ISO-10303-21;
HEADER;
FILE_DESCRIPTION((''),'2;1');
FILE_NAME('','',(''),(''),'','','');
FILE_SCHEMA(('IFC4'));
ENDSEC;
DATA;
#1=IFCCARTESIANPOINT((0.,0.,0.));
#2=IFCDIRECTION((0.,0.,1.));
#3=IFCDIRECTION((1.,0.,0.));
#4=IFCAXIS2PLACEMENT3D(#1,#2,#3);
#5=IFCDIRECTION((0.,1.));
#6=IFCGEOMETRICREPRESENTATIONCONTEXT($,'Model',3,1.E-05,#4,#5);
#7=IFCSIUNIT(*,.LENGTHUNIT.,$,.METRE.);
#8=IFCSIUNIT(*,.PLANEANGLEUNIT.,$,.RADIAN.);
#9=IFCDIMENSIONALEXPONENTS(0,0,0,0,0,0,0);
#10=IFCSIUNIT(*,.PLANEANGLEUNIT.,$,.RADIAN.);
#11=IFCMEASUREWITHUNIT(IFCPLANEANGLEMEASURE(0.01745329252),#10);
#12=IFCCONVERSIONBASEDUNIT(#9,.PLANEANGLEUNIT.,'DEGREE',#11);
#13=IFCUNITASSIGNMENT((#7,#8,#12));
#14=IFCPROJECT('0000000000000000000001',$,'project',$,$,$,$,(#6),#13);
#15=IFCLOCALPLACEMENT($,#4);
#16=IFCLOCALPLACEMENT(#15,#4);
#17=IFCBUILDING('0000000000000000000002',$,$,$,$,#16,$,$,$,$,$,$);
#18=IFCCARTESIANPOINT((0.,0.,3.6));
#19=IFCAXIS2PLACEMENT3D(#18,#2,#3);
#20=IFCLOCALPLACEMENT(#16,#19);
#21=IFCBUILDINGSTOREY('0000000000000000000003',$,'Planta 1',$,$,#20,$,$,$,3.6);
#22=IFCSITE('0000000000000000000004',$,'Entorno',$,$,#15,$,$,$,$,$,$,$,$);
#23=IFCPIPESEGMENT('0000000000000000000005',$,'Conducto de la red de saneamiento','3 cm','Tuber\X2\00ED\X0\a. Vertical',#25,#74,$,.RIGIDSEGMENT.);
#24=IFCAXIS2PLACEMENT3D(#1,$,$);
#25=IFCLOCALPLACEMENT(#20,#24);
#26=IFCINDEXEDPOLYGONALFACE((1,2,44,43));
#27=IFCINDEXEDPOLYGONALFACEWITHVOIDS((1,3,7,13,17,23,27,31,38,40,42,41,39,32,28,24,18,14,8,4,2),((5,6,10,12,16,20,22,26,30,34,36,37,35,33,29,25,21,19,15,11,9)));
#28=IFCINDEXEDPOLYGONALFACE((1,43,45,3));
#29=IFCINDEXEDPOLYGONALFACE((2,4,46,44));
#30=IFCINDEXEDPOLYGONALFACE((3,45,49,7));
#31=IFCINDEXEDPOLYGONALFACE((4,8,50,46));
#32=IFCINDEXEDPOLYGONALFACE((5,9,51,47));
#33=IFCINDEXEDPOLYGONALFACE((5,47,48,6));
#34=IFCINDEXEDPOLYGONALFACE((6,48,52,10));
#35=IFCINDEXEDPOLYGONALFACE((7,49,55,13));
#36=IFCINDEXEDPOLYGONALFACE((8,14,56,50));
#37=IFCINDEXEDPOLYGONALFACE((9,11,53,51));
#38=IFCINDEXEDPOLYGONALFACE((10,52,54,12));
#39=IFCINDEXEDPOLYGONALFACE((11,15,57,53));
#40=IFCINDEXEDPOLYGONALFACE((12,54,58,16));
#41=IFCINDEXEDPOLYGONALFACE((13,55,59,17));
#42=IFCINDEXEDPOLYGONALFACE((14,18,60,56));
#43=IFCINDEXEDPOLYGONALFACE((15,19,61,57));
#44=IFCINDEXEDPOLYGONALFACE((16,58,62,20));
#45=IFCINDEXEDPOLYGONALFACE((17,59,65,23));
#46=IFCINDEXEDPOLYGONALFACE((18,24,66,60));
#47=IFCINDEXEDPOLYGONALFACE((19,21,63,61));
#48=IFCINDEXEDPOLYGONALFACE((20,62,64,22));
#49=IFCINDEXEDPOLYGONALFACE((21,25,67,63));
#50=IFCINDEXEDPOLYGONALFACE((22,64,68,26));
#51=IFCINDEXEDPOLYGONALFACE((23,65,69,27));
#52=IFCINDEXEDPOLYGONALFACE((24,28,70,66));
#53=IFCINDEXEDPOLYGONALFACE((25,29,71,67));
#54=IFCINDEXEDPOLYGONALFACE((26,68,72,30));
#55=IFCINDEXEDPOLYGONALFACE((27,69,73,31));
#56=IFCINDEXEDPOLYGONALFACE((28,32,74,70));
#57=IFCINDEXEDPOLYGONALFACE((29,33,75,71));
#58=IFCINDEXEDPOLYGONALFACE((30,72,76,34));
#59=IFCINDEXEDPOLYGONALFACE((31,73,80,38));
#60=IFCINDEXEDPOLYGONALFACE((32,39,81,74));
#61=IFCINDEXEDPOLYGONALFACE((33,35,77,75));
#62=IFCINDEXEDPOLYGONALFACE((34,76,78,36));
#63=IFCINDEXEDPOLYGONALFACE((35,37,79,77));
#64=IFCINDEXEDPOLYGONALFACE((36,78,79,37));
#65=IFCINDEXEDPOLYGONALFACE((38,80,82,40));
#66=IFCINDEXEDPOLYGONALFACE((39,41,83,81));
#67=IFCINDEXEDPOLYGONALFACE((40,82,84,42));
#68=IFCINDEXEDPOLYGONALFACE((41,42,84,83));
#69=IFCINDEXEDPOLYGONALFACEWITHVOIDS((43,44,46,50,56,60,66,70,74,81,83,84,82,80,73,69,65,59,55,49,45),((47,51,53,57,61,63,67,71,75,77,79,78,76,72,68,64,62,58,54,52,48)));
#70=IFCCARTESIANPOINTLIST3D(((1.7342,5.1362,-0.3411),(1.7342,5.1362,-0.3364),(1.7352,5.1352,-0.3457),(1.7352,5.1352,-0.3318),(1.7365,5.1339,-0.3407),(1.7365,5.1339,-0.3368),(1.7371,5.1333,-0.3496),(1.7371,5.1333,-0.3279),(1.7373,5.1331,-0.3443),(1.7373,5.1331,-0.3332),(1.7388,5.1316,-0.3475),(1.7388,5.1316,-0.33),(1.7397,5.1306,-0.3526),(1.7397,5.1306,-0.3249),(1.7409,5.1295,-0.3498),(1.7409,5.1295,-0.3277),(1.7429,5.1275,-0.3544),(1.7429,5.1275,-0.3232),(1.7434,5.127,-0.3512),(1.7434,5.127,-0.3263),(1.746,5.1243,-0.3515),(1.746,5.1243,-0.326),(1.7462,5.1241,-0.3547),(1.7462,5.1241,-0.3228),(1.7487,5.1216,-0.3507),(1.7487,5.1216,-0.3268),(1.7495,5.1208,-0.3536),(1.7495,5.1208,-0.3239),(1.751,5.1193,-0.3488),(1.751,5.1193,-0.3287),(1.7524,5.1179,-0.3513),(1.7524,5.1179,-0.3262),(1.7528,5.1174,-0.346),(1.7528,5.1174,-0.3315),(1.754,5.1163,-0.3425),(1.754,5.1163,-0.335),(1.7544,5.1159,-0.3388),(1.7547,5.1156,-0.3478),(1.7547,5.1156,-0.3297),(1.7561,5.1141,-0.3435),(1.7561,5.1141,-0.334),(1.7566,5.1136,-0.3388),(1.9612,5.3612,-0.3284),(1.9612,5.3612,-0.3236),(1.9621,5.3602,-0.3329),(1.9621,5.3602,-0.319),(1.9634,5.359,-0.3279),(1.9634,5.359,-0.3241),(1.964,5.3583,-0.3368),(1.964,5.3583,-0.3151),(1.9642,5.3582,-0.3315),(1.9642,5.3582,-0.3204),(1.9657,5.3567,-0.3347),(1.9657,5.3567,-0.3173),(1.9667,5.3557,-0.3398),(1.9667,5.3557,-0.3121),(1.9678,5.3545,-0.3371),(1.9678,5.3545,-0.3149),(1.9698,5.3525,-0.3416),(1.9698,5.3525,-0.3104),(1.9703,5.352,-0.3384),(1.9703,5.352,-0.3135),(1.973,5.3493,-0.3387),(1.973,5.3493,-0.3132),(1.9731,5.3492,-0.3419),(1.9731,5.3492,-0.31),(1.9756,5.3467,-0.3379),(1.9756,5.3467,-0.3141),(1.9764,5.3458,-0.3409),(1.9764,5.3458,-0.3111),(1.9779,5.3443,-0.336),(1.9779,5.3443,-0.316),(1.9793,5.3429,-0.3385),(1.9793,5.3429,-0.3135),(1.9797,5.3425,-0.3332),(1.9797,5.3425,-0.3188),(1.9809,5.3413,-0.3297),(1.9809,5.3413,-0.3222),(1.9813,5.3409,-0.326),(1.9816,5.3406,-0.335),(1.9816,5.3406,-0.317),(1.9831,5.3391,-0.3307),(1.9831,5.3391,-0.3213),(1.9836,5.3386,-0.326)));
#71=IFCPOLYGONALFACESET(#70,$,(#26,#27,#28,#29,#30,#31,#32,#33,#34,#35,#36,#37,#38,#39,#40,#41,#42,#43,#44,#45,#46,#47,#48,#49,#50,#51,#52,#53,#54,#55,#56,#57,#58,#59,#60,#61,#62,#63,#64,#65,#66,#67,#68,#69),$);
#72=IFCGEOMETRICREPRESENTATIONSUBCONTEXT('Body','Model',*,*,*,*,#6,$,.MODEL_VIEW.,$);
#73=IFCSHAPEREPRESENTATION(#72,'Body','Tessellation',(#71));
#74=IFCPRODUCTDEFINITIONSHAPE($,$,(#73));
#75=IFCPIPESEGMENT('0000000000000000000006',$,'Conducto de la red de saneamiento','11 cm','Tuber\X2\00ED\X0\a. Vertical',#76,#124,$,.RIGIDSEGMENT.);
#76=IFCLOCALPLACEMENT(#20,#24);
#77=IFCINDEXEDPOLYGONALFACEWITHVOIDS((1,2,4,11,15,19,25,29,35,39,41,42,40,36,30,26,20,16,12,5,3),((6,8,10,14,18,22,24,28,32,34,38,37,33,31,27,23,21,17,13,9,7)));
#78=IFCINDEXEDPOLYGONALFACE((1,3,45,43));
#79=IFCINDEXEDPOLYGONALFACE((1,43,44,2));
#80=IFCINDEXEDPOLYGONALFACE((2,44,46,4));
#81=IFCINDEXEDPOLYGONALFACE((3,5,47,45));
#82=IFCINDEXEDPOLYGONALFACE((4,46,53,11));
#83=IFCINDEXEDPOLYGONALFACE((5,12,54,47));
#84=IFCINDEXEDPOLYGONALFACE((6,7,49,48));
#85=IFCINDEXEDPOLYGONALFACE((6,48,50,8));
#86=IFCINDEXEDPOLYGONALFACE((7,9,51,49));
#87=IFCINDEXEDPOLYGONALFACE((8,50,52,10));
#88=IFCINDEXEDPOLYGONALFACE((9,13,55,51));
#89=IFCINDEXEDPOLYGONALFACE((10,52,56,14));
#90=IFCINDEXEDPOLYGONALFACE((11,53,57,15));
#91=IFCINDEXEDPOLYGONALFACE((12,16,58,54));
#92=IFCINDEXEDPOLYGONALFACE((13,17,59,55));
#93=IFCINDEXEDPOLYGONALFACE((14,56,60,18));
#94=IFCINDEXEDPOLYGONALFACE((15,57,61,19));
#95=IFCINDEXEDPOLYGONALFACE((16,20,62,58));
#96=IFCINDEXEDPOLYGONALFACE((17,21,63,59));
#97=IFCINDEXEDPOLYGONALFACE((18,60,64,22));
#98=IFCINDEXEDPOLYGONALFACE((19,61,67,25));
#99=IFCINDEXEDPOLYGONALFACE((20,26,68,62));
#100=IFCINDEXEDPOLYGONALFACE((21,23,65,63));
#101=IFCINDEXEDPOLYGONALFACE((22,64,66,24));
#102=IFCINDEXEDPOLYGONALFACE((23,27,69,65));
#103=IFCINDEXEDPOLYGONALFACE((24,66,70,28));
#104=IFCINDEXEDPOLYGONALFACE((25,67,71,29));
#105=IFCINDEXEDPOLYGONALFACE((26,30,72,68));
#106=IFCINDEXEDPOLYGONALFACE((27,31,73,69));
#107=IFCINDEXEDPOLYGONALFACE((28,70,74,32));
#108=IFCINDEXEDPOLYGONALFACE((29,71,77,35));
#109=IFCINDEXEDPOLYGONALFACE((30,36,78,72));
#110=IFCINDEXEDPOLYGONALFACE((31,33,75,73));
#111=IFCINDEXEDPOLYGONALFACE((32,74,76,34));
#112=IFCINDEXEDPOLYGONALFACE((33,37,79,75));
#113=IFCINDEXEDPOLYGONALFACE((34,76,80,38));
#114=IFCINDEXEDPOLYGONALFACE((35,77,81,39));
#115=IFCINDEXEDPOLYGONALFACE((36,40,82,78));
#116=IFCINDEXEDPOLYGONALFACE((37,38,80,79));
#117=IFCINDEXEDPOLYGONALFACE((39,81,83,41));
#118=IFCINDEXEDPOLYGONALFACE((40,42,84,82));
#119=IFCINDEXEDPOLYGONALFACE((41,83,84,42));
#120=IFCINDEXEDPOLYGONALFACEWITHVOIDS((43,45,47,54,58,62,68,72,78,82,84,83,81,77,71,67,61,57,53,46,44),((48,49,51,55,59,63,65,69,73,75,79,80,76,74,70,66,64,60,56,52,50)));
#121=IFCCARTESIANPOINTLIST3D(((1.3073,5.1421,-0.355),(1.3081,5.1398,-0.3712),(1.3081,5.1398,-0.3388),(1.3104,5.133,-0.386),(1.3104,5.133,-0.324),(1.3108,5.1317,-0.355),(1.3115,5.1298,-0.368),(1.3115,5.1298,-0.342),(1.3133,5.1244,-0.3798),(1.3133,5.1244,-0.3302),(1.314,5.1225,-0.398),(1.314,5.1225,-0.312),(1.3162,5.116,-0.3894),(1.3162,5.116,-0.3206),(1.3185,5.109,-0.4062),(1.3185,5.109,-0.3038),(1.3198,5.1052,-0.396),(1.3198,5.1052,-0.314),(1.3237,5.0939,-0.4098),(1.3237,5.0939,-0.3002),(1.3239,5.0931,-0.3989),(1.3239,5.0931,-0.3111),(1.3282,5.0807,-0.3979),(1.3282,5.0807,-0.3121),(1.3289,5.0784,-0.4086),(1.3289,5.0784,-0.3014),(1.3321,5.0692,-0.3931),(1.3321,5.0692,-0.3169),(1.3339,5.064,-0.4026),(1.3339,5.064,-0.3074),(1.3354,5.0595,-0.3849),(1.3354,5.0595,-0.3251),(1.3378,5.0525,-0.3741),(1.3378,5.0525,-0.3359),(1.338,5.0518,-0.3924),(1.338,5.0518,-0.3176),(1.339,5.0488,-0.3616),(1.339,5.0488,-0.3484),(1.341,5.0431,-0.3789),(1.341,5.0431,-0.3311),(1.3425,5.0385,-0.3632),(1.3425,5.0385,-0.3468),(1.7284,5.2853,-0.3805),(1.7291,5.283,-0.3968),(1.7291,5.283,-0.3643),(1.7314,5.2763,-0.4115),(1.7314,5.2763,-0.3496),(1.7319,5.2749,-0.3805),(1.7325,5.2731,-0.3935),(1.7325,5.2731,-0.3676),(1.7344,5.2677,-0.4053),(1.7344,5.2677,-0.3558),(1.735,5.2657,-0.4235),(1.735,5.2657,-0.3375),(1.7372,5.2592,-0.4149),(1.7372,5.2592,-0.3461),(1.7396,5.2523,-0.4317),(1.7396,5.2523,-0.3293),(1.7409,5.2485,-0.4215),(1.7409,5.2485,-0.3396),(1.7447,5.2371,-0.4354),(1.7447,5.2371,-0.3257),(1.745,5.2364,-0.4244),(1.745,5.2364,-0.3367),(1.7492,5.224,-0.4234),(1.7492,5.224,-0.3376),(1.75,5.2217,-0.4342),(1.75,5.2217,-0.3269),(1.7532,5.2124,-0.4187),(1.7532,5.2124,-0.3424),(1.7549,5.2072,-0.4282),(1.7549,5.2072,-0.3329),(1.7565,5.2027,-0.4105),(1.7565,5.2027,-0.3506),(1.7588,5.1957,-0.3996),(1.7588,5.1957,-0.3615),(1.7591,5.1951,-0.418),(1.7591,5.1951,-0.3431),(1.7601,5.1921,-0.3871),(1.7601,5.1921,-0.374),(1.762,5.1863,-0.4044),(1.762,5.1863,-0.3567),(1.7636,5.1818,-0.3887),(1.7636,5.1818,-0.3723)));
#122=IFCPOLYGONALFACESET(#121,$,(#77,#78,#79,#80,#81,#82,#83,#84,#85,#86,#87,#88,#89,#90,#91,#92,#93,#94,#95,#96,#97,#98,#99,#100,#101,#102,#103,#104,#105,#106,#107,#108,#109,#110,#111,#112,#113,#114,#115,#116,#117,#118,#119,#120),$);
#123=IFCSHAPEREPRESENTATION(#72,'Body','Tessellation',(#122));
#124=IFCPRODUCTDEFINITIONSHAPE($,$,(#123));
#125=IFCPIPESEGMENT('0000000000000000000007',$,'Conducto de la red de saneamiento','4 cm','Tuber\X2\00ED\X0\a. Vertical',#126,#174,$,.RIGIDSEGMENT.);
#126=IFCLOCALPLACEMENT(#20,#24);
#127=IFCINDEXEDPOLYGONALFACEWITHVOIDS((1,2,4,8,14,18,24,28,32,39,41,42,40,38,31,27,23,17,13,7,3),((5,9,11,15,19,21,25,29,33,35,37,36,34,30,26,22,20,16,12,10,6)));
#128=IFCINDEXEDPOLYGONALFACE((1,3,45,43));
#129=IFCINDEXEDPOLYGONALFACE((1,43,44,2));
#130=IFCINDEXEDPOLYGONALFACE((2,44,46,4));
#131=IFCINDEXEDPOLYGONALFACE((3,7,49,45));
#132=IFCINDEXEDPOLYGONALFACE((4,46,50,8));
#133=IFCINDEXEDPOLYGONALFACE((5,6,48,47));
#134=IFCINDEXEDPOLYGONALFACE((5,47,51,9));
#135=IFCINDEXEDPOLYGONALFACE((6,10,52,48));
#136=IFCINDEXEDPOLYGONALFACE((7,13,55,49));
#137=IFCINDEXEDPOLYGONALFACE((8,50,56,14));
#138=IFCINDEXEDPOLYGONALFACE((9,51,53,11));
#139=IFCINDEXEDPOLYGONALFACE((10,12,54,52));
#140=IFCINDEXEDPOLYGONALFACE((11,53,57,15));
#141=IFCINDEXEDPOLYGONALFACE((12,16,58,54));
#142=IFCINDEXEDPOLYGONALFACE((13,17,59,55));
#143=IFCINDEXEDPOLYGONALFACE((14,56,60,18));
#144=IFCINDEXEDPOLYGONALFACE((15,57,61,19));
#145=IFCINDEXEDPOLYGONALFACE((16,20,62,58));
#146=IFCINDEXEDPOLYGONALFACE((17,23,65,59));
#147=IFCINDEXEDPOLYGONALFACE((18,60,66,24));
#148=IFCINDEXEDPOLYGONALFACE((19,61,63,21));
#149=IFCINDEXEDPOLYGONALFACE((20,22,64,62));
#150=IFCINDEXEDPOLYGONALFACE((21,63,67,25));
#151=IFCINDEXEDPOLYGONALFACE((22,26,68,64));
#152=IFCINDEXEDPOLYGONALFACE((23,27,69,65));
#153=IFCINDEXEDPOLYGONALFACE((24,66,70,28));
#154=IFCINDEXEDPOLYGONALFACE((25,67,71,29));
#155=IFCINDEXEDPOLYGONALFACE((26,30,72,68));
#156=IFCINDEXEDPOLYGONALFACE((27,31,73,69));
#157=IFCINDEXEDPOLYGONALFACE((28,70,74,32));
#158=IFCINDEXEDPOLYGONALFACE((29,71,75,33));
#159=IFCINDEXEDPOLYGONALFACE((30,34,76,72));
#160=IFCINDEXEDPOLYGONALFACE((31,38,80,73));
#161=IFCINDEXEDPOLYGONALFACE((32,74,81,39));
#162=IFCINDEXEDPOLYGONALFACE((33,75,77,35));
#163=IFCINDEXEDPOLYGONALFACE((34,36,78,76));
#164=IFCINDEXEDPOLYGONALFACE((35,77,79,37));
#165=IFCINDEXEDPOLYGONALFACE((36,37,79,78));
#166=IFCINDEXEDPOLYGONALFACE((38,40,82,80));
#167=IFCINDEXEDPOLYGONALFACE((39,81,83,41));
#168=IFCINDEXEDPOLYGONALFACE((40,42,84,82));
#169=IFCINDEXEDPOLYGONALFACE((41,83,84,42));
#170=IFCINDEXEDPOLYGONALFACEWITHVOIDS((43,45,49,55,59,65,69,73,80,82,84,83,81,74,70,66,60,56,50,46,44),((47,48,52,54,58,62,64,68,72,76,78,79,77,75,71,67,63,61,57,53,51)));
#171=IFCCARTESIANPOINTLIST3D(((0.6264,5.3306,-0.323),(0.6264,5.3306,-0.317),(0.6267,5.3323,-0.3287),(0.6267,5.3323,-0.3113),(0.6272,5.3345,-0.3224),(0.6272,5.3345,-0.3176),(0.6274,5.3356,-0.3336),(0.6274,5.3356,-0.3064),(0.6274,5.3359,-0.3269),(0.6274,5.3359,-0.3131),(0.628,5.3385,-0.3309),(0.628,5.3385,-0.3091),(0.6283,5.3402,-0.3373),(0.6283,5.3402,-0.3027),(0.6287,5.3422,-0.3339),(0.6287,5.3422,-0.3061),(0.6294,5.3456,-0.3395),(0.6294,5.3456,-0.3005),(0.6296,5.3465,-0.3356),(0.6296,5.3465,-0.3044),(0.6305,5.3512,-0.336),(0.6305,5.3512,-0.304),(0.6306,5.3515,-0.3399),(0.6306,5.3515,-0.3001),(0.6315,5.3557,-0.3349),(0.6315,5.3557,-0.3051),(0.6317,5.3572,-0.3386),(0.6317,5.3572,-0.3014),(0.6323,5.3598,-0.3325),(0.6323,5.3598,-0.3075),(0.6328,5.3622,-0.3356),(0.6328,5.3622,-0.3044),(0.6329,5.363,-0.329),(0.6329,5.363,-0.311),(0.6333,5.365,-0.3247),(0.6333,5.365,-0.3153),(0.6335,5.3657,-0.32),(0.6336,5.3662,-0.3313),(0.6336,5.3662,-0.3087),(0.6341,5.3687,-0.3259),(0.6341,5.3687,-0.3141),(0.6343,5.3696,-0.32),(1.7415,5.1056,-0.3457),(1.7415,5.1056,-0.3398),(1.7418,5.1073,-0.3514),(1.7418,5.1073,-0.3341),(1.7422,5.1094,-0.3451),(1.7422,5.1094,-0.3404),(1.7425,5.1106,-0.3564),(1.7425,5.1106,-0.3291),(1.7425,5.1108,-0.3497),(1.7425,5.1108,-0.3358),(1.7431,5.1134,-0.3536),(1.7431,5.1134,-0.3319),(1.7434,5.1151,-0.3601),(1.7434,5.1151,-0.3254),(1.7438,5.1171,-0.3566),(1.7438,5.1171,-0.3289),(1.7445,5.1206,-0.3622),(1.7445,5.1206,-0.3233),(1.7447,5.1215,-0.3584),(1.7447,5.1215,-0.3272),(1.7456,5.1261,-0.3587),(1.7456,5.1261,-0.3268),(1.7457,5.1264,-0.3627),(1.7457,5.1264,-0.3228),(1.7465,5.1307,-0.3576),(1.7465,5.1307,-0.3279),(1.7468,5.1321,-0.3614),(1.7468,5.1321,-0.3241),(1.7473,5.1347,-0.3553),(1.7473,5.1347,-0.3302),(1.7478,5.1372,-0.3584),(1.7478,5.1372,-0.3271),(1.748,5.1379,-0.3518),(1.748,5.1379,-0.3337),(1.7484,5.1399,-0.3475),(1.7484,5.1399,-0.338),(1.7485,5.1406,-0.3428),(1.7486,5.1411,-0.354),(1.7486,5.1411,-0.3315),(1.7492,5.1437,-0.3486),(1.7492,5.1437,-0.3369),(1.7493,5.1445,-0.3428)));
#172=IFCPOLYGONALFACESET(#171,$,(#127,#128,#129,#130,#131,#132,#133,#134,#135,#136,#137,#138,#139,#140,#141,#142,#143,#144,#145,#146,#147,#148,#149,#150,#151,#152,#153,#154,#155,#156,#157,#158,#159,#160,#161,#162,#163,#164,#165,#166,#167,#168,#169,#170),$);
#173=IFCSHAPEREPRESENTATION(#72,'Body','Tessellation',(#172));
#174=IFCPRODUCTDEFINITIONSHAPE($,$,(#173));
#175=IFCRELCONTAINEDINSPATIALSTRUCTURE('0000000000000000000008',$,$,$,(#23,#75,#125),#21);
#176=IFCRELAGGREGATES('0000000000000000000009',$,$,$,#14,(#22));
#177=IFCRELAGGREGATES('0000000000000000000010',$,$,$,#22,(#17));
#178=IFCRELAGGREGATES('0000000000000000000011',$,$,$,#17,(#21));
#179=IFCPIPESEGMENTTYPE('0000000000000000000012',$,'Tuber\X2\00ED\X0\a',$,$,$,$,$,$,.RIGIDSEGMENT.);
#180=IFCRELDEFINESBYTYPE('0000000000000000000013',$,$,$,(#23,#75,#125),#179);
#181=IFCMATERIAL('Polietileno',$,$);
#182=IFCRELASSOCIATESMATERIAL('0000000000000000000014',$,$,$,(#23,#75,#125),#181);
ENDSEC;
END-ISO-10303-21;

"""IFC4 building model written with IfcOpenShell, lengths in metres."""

from ifc_helpers import new_model, entity, si_unit, converted_unit, direction, frame, origin_with_axes, origin_2d_with_axis, place, context, subcontext, project, spatial, hollow_circle, extrude, material, type_object, element, save


model = new_model("IFC4")

# Units and contexts
model_context = context("Model", 3, precision=1e-05, world=origin_with_axes(), true_north=direction((0.0, 1.0)))
body_context = subcontext(model_context, "Body", "Model", "MODEL_VIEW")
ifc_project = project(units=[si_unit("LENGTHUNIT", "METRE"), si_unit("PLANEANGLEUNIT", "RADIAN"), converted_unit("PLANEANGLEUNIT", "DEGREE", entity("IfcPlaneAngleMeasure", 0.01745329252), si_unit("PLANEANGLEUNIT", "RADIAN"), dimensions=[0, 0, 0, 0, 0, 0, 0])], contexts=[model_context])

# Site, building, storey
site_placement = place(None, origin_with_axes())
site = spatial("IfcSite", under=ifc_project, at=site_placement, Name="Entorno")
building_placement = place(site_placement, origin_with_axes())
building = spatial("IfcBuilding", under=site, at=building_placement)
storey_placement = place(building_placement, frame((0.0, 0.0, 3.6), z_axis=(0.0, 0.0, 1.0), x_axis=(1.0, 0.0, 0.0)))
storey = spatial("IfcBuildingStorey", under=building, at=storey_placement, Name="Planta 1", Elevation=3.6)

# Shared definitions
ifc_material_1 = material(Name="Polietileno")

# Pipe segments
pipe_segment_type_1 = type_object("IfcPipeSegmentType", Name="Tubería", PredefinedType="RIGIDSEGMENT")
pipe_segment_1_placement = place(storey_placement, frame((1.9723, 5.35, -0.326), z_axis=(-0.710019, -0.704183, 0.0), x_axis=(0.704183, -0.710019, 0.0)))
element("IfcPipeSegment", 1, at=pipe_segment_1_placement, inside=storey, type_object=pipe_segment_type_1, material=ifc_material_1, Name="Conducto de la red de saneamiento", Description="3 cm", ObjectType="Tubería. Vertical", PredefinedType="RIGIDSEGMENT", context=body_context, shape_type="SweptSolid", body=[
    extrude(hollow_circle(Radius=0.016, WallThickness=0.0032, at=origin_2d_with_axis()), origin_with_axes(), (0.0, -0.039968, 0.999201), 0.3199),
])
pipe_segment_2_placement = place(storey_placement, frame((1.325, 5.09, -0.355), z_axis=(0.946709, 0.322089, 0.0), x_axis=(-0.322089, 0.946709, 0.0)))
element("IfcPipeSegment", 2, at=pipe_segment_2_placement, inside=storey, type_object=pipe_segment_type_1, material=ifc_material_1, Name="Conducto de la red de saneamiento", Description="11 cm", ObjectType="Tubería. Vertical", PredefinedType="RIGIDSEGMENT", context=body_context, shape_type="SweptSolid", body=[
    extrude(hollow_circle(Radius=0.055, WallThickness=0.011, at=origin_2d_with_axis()), origin_with_axes(), (0.0, -0.057341, 0.998355), 0.4455),
])
pipe_segment_3_placement = place(storey_placement, frame((0.6303, 5.35, -0.32), z_axis=(0.980234, -0.197841, 0.0), x_axis=(0.197841, 0.980234, 0.0)))
element("IfcPipeSegment", 3, at=pipe_segment_3_placement, inside=storey, type_object=pipe_segment_type_1, material=ifc_material_1, Name="Conducto de la red de saneamiento", Description="4 cm", ObjectType="Tubería. Vertical", PredefinedType="RIGIDSEGMENT", context=body_context, shape_type="SweptSolid", body=[
    extrude(hollow_circle(Radius=0.02, WallThickness=0.004, at=origin_2d_with_axis()), origin_with_axes(), (0.0, -0.019996, 0.9998), 1.1378),
])

save(model, "model.ifc")
